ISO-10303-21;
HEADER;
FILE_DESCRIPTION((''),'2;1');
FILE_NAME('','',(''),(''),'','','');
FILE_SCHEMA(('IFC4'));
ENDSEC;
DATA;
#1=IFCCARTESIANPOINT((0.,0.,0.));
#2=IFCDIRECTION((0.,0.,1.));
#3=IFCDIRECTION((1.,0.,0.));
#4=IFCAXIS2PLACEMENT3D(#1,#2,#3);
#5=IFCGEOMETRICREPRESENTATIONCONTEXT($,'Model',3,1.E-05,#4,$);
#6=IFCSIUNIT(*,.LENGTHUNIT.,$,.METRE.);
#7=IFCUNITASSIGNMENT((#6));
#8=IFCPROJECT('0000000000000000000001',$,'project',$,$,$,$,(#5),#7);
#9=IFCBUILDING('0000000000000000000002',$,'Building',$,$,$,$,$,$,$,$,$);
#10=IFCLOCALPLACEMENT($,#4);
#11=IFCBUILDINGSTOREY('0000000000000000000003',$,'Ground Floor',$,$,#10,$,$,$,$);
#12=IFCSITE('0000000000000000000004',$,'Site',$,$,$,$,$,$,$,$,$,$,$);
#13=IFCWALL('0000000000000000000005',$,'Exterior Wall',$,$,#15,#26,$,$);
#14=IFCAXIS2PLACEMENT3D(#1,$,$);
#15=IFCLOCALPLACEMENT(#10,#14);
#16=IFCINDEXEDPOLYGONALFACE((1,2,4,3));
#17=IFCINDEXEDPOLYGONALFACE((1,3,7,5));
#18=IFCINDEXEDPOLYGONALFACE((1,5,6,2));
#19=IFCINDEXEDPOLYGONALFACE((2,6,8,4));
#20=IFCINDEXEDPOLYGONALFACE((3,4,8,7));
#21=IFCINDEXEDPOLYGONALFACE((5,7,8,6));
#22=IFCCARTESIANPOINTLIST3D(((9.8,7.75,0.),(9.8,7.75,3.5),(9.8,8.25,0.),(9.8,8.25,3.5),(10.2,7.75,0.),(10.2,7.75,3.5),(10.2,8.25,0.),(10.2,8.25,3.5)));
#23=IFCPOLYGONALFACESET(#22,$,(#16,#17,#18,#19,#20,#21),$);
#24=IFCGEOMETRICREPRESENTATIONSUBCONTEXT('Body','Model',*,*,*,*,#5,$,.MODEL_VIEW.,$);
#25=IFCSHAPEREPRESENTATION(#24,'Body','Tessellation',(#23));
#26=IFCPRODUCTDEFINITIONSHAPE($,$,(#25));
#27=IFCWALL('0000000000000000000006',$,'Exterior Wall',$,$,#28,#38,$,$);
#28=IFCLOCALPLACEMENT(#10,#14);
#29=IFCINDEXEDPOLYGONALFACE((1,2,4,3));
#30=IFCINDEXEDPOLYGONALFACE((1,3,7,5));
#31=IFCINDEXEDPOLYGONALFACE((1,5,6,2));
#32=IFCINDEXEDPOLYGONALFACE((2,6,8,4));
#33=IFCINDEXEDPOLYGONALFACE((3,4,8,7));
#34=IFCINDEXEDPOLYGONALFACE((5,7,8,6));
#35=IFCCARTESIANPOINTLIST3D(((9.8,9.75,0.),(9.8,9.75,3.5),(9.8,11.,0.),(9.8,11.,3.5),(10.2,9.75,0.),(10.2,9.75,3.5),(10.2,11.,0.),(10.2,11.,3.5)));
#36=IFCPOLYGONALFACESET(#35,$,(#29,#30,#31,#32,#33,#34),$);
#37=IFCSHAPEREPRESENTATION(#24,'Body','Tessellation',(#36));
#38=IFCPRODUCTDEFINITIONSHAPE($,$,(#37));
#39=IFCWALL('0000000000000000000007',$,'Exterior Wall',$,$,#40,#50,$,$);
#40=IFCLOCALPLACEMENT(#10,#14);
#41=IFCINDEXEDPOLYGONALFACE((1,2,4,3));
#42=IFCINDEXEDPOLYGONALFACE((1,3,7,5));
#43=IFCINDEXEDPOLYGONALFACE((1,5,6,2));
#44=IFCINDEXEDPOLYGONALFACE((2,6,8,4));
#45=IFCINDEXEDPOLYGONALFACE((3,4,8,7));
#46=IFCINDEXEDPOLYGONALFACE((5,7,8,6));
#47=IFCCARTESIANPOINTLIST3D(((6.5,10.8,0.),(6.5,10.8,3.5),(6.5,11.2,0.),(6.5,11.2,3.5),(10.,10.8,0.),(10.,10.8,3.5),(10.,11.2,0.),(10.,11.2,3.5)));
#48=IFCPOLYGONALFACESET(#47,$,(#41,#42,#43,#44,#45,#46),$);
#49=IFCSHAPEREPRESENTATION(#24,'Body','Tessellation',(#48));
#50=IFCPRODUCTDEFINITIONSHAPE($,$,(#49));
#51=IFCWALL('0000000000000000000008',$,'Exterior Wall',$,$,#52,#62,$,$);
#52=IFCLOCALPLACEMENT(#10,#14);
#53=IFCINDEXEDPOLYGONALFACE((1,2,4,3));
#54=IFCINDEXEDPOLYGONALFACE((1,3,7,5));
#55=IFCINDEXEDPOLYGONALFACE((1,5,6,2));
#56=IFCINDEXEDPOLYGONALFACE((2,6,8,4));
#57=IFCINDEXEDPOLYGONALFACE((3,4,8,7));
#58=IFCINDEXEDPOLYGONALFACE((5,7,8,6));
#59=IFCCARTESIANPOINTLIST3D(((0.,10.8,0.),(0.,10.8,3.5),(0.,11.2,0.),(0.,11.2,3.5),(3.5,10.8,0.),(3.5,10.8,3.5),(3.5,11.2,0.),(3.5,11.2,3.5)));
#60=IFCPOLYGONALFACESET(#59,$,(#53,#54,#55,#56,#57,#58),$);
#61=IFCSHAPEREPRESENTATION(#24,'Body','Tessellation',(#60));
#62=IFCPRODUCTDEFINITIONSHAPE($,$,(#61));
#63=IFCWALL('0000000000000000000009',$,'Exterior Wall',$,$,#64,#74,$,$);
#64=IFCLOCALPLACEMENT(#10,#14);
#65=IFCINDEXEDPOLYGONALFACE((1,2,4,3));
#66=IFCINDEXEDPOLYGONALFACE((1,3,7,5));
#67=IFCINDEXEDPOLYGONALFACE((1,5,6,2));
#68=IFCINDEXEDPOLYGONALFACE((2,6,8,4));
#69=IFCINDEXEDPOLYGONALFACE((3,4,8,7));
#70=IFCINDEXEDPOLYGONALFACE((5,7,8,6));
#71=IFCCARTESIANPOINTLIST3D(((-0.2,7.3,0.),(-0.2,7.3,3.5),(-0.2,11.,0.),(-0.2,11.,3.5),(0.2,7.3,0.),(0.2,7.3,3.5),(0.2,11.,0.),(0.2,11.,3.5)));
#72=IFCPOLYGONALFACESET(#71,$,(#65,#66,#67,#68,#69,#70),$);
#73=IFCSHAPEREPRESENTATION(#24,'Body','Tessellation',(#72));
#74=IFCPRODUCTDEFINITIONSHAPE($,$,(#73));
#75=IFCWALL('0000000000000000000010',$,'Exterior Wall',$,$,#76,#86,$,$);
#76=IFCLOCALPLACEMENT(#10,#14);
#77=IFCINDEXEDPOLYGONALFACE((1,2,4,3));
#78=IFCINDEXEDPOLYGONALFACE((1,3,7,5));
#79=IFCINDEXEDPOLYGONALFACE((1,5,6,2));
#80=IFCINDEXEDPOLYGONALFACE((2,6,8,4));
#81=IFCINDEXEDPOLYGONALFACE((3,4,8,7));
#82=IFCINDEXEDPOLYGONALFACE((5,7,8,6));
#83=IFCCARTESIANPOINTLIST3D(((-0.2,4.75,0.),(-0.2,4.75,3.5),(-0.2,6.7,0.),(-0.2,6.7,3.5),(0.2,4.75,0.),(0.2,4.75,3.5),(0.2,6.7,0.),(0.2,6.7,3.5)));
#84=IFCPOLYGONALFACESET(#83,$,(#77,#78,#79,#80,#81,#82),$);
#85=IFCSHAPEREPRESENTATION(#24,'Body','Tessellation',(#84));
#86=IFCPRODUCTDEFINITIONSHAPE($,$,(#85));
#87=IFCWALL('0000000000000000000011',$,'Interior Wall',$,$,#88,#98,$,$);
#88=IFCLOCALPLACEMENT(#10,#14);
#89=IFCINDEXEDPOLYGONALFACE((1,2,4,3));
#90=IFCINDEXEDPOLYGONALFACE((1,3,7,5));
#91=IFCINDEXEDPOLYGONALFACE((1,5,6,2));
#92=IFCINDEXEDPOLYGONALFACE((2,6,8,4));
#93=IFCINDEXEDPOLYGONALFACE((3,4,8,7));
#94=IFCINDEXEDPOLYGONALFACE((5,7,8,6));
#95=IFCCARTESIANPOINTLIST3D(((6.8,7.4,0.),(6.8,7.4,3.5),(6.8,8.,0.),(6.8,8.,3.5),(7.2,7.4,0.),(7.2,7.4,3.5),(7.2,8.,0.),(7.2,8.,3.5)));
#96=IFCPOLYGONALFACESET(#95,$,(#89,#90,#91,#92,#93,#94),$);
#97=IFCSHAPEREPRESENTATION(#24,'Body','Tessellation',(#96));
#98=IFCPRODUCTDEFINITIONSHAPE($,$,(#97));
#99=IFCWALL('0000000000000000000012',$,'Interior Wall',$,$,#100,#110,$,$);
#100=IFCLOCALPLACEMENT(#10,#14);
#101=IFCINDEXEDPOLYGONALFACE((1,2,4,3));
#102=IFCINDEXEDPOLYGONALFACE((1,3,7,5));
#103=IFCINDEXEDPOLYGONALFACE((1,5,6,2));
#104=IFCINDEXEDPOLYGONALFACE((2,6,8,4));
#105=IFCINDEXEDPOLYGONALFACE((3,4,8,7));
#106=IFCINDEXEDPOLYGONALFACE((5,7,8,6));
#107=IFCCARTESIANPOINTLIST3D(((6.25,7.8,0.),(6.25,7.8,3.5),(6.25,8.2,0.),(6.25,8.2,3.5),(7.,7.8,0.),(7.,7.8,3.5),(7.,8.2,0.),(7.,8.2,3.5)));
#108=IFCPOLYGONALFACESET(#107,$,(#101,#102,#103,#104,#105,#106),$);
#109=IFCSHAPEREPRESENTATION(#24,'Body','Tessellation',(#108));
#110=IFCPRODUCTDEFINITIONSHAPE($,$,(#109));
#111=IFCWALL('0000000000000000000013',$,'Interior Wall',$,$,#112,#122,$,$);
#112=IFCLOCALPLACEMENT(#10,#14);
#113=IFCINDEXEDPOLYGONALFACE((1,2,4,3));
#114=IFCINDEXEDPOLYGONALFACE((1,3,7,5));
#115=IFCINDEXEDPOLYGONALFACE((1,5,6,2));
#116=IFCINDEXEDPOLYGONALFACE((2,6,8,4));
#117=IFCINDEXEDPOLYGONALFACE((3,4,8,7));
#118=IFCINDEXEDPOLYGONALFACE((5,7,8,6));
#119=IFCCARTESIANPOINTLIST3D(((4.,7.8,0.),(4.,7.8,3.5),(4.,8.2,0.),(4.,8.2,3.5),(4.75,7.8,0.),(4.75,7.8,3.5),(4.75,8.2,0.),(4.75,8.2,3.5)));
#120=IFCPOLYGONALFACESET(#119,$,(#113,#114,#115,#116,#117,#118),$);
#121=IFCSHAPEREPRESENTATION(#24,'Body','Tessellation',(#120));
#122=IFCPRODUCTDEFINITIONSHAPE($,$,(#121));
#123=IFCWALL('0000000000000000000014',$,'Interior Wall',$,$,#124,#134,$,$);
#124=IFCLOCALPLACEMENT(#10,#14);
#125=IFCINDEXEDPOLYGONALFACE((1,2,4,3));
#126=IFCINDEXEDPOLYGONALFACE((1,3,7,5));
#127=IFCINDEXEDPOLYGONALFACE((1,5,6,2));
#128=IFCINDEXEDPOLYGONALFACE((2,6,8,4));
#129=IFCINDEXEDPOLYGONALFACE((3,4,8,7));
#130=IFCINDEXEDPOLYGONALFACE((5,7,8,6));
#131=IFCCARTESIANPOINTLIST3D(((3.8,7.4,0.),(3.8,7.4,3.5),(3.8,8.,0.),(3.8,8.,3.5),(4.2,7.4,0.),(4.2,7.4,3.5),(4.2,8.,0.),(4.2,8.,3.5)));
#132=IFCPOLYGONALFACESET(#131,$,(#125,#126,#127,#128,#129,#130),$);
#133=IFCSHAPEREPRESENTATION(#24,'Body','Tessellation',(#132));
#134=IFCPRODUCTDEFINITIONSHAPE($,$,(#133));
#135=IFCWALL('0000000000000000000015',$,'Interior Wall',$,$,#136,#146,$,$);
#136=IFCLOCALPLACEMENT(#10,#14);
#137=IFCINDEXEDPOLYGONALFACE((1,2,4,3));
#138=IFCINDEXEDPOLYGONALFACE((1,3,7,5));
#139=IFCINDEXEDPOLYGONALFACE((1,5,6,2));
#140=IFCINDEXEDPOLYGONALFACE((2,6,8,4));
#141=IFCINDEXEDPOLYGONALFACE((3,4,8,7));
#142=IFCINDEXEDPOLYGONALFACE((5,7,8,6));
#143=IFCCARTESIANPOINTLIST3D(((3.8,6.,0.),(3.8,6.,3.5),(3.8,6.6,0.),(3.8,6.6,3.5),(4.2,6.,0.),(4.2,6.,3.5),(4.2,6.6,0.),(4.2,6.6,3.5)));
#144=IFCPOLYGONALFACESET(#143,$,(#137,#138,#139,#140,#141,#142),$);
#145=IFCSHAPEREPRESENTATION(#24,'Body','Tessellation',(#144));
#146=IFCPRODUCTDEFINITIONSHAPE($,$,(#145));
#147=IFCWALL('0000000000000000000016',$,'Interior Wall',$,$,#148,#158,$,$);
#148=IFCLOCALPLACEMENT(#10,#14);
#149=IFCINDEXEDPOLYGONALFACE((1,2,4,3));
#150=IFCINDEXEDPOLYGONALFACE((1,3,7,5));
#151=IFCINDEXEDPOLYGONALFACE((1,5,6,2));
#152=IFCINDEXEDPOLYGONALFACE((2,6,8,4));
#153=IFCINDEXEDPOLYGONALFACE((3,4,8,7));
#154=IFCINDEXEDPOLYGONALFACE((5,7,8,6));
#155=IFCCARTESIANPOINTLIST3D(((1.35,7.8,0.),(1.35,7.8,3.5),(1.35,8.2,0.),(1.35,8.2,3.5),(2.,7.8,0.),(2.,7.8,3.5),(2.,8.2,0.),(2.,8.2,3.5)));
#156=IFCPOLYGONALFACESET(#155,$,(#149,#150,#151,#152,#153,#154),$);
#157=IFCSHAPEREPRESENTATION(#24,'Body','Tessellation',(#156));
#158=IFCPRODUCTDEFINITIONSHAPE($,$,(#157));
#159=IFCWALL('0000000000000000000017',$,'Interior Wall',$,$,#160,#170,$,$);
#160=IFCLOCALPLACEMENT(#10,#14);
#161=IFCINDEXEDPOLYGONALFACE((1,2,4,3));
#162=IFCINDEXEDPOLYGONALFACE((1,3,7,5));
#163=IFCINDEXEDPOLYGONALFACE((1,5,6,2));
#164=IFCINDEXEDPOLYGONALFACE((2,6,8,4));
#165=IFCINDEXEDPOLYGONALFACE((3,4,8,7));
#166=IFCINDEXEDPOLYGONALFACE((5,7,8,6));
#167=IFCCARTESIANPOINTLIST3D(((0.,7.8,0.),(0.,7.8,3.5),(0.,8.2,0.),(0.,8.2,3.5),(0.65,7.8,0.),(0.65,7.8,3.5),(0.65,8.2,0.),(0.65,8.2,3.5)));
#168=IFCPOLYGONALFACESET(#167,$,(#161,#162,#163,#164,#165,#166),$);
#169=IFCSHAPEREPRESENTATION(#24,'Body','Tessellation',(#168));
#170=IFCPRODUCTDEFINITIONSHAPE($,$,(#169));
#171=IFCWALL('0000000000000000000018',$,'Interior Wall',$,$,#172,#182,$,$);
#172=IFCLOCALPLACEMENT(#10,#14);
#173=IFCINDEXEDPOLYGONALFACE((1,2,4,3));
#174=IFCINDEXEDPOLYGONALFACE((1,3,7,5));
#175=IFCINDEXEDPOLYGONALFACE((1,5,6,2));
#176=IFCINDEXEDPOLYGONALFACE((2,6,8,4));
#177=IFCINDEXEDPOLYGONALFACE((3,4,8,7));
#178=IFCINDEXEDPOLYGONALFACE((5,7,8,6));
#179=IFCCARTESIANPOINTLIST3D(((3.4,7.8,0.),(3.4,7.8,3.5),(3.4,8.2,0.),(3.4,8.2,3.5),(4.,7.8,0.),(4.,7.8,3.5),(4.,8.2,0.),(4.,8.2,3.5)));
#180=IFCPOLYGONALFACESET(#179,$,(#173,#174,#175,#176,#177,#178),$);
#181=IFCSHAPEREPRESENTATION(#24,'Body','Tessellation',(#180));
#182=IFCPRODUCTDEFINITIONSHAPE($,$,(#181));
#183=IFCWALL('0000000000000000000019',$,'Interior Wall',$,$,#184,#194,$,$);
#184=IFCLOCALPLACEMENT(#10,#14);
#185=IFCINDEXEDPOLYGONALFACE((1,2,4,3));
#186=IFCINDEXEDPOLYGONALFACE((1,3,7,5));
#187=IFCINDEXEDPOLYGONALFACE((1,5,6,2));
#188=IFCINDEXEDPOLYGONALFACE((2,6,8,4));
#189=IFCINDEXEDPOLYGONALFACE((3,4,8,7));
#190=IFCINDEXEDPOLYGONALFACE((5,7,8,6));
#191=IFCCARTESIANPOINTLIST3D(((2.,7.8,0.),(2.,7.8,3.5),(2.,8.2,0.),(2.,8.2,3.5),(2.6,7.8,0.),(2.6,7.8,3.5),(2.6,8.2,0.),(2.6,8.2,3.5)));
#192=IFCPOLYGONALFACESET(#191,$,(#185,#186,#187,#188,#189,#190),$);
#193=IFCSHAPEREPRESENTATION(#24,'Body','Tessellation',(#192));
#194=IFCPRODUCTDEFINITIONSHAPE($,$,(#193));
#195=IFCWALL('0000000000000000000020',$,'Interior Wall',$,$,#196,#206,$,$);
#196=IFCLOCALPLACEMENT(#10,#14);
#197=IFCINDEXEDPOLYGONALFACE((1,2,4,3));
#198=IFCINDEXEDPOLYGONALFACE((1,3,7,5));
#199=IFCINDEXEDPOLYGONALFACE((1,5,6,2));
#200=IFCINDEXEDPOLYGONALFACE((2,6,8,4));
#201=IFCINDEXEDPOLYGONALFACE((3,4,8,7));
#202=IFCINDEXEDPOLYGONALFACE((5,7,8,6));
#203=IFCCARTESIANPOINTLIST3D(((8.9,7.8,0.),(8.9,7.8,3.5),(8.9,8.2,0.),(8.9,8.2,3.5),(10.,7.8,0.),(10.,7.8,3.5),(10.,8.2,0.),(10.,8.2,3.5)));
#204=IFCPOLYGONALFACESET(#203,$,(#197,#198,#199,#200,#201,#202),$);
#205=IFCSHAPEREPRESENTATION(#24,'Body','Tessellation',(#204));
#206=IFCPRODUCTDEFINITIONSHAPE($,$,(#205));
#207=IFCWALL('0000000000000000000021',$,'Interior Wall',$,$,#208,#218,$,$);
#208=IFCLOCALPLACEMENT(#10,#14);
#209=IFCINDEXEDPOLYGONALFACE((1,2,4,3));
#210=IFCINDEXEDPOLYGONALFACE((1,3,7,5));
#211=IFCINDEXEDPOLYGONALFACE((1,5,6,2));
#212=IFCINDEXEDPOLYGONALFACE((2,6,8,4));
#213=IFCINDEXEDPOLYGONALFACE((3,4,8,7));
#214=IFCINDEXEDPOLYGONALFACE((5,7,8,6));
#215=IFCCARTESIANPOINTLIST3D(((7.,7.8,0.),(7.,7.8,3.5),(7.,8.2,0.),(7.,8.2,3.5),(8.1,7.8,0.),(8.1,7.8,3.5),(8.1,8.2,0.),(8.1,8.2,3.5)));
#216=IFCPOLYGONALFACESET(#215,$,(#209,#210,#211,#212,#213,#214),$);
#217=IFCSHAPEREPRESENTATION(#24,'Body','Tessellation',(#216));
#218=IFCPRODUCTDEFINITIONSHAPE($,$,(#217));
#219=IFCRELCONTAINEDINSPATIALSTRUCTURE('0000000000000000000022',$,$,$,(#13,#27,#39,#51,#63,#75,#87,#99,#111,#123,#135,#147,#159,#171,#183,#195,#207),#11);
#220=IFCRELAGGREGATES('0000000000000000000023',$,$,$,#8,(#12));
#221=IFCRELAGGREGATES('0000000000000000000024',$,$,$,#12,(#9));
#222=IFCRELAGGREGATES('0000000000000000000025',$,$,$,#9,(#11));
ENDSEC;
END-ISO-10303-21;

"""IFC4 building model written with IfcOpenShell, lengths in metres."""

from ifc_helpers import new_model, si_unit, frame, origin_with_axes, place, context, subcontext, project, spatial, indexed_curve, outline, extrude, element, save


model = new_model("IFC4")

# Units and contexts
model_context = context("Model", 3, precision=1e-05, world=origin_with_axes())
body_context = subcontext(model_context, "Body", "Model", "MODEL_VIEW")
ifc_project = project(units=[si_unit("LENGTHUNIT", "METRE")], contexts=[model_context])

# Site, building, storey
site = spatial("IfcSite", under=ifc_project, Name="Site")
building = spatial("IfcBuilding", under=site, Name="Building")
storey_placement = place(None, origin_with_axes())
storey = spatial("IfcBuildingStorey", under=building, at=storey_placement, Name="Ground Floor")

# Walls
wall_1_placement = place(storey_placement, frame((10.0, 7.75, 0.0), z_axis=(0.0, 0.0, 1.0), x_axis=(0.0, 1.0, 0.0)))
element("IfcWall", 1, at=wall_1_placement, inside=storey, Name="Exterior Wall", context=body_context, shape_type="SweptSolid", body=[
    extrude(outline(indexed_curve([(0.0, 0.0), (0.0, 0.4), (0.5, 0.4), (0.5, 0.0), (0.0, 0.0)], self_intersect=False)), frame((0.0, -0.2, 0.0), z_axis=(0.0, 0.0, 1.0), x_axis=(1.0, 0.0, 0.0)), (0.0, 0.0, 1.0), 3.5),
])
wall_2_placement = place(storey_placement, frame((10.0, 9.75, 0.0), z_axis=(0.0, 0.0, 1.0), x_axis=(0.0, 1.0, 0.0)))
element("IfcWall", 2, at=wall_2_placement, inside=storey, Name="Exterior Wall", context=body_context, shape_type="SweptSolid", body=[
    extrude(outline(indexed_curve([(0.0, 0.0), (0.0, 0.4), (1.25, 0.4), (1.25, 0.0), (0.0, 0.0)], self_intersect=False)), frame((0.0, -0.2, 0.0), z_axis=(0.0, 0.0, 1.0), x_axis=(1.0, 0.0, 0.0)), (0.0, 0.0, 1.0), 3.5),
])
for number, where, z_axis, x_axis, name in (
    (3, (10.0, 11.0, 0.0), (0.0, 0.0, 1.0), (-1.0, 0.0, 0.0), "Exterior Wall"),
    (4, (3.5, 11.0, 0.0), (0.0, 0.0, 1.0), (-1.0, 0.0, 0.0), "Exterior Wall"),
):
    element("IfcWall", number, at=place(storey_placement, frame(where, z_axis=z_axis, x_axis=x_axis)), inside=storey, Name=name, context=body_context, shape_type="SweptSolid", body=[
        extrude(outline(indexed_curve([(0.0, 0.0), (0.0, 0.4), (3.5, 0.4), (3.5, 0.0), (0.0, 0.0)], self_intersect=False)), frame((0.0, -0.2, 0.0), z_axis=(0.0, 0.0, 1.0), x_axis=(1.0, 0.0, 0.0)), (0.0, 0.0, 1.0), 3.5),
    ])
wall_3_placement = place(storey_placement, frame((0.0, 11.0, 0.0), z_axis=(0.0, 0.0, 1.0), x_axis=(0.0, -1.0, 0.0)))
element("IfcWall", 5, at=wall_3_placement, inside=storey, Name="Exterior Wall", context=body_context, shape_type="SweptSolid", body=[
    extrude(outline(indexed_curve([(0.0, 0.0), (0.0, 0.4), (3.7, 0.4), (3.7, 0.0), (0.0, 0.0)], self_intersect=False)), frame((0.0, -0.2, 0.0), z_axis=(0.0, 0.0, 1.0), x_axis=(1.0, 0.0, 0.0)), (0.0, 0.0, 1.0), 3.5),
])
wall_4_placement = place(storey_placement, frame((0.0, 6.7, 0.0), z_axis=(0.0, 0.0, 1.0), x_axis=(0.0, -1.0, 0.0)))
element("IfcWall", 6, at=wall_4_placement, inside=storey, Name="Exterior Wall", context=body_context, shape_type="SweptSolid", body=[
    extrude(outline(indexed_curve([(0.0, 0.0), (0.0, 0.4), (1.95, 0.4), (1.95, 0.0), (0.0, 0.0)], self_intersect=False)), frame((0.0, -0.2, 0.0), z_axis=(0.0, 0.0, 1.0), x_axis=(1.0, 0.0, 0.0)), (0.0, 0.0, 1.0), 3.5),
])
wall_5_placement = place(storey_placement, frame((7.0, 7.4, 0.0), z_axis=(0.0, 0.0, 1.0), x_axis=(0.0, 1.0, 0.0)))
element("IfcWall", 7, at=wall_5_placement, inside=storey, Name="Interior Wall", context=body_context, shape_type="SweptSolid", body=[
    extrude(outline(indexed_curve([(0.0, 0.0), (0.0, 0.4), (0.6, 0.4), (0.6, 0.0), (0.0, 0.0)], self_intersect=False)), frame((0.0, -0.2, 0.0), z_axis=(0.0, 0.0, 1.0), x_axis=(1.0, 0.0, 0.0)), (0.0, 0.0, 1.0), 3.5),
])
for number, where, z_axis, x_axis, name in (
    (8, (7.0, 8.0, 0.0), (0.0, 0.0, 1.0), (-1.0, 0.0, 0.0), "Interior Wall"),
    (9, (4.75, 8.0, 0.0), (0.0, 0.0, 1.0), (-1.0, 0.0, 0.0), "Interior Wall"),
):
    element("IfcWall", number, at=place(storey_placement, frame(where, z_axis=z_axis, x_axis=x_axis)), inside=storey, Name=name, context=body_context, shape_type="SweptSolid", body=[
        extrude(outline(indexed_curve([(0.0, 0.0), (0.0, 0.4), (0.75, 0.4), (0.75, 0.0), (0.0, 0.0)], self_intersect=False)), frame((0.0, -0.2, 0.0), z_axis=(0.0, 0.0, 1.0), x_axis=(1.0, 0.0, 0.0)), (0.0, 0.0, 1.0), 3.5),
    ])
for number, where, z_axis, x_axis, name in (
    (10, (4.0, 8.0, 0.0), (0.0, 0.0, 1.0), (0.0, -1.0, 0.0), "Interior Wall"),
    (11, (4.0, 6.6, 0.0), (0.0, 0.0, 1.0), (0.0, -1.0, 0.0), "Interior Wall"),
):
    element("IfcWall", number, at=place(storey_placement, frame(where, z_axis=z_axis, x_axis=x_axis)), inside=storey, Name=name, context=body_context, shape_type="SweptSolid", body=[
        extrude(outline(indexed_curve([(0.0, 0.0), (0.0, 0.4), (0.6, 0.4), (0.6, 0.0), (0.0, 0.0)], self_intersect=False)), frame((0.0, -0.2, 0.0), z_axis=(0.0, 0.0, 1.0), x_axis=(1.0, 0.0, 0.0)), (0.0, 0.0, 1.0), 3.5),
    ])
for number, where, z_axis, x_axis, name in (
    (12, (2.0, 8.0, 0.0), (0.0, 0.0, 1.0), (-1.0, 0.0, 0.0), "Interior Wall"),
    (13, (0.65, 8.0, 0.0), (0.0, 0.0, 1.0), (-1.0, 0.0, 0.0), "Interior Wall"),
):
    element("IfcWall", number, at=place(storey_placement, frame(where, z_axis=z_axis, x_axis=x_axis)), inside=storey, Name=name, context=body_context, shape_type="SweptSolid", body=[
        extrude(outline(indexed_curve([(0.0, 0.0), (0.0, 0.4), (0.65, 0.4), (0.65, 0.0), (0.0, 0.0)], self_intersect=False)), frame((0.0, -0.2, 0.0), z_axis=(0.0, 0.0, 1.0), x_axis=(1.0, 0.0, 0.0)), (0.0, 0.0, 1.0), 3.5),
    ])
for number, where, z_axis, x_axis, name in (
    (14, (4.0, 8.0, 0.0), (0.0, 0.0, 1.0), (-1.0, 0.0, 0.0), "Interior Wall"),
    (15, (2.6, 8.0, 0.0), (0.0, 0.0, 1.0), (-1.0, 0.0, 0.0), "Interior Wall"),
):
    element("IfcWall", number, at=place(storey_placement, frame(where, z_axis=z_axis, x_axis=x_axis)), inside=storey, Name=name, context=body_context, shape_type="SweptSolid", body=[
        extrude(outline(indexed_curve([(0.0, 0.0), (0.0, 0.4), (0.6, 0.4), (0.6, 0.0), (0.0, 0.0)], self_intersect=False)), frame((0.0, -0.2, 0.0), z_axis=(0.0, 0.0, 1.0), x_axis=(1.0, 0.0, 0.0)), (0.0, 0.0, 1.0), 3.5),
    ])
for number, where, z_axis, x_axis, name in (
    (16, (10.0, 8.0, 0.0), (0.0, 0.0, 1.0), (-1.0, 0.0, 0.0), "Interior Wall"),
    (17, (8.1, 8.0, 0.0), (0.0, 0.0, 1.0), (-1.0, 0.0, 0.0), "Interior Wall"),
):
    element("IfcWall", number, at=place(storey_placement, frame(where, z_axis=z_axis, x_axis=x_axis)), inside=storey, Name=name, context=body_context, shape_type="SweptSolid", body=[
        extrude(outline(indexed_curve([(0.0, 0.0), (0.0, 0.4), (1.1, 0.4), (1.1, 0.0), (0.0, 0.0)], self_intersect=False)), frame((0.0, -0.2, 0.0), z_axis=(0.0, 0.0, 1.0), x_axis=(1.0, 0.0, 0.0)), (0.0, 0.0, 1.0), 3.5),
    ])

save(model, "model.ifc")
